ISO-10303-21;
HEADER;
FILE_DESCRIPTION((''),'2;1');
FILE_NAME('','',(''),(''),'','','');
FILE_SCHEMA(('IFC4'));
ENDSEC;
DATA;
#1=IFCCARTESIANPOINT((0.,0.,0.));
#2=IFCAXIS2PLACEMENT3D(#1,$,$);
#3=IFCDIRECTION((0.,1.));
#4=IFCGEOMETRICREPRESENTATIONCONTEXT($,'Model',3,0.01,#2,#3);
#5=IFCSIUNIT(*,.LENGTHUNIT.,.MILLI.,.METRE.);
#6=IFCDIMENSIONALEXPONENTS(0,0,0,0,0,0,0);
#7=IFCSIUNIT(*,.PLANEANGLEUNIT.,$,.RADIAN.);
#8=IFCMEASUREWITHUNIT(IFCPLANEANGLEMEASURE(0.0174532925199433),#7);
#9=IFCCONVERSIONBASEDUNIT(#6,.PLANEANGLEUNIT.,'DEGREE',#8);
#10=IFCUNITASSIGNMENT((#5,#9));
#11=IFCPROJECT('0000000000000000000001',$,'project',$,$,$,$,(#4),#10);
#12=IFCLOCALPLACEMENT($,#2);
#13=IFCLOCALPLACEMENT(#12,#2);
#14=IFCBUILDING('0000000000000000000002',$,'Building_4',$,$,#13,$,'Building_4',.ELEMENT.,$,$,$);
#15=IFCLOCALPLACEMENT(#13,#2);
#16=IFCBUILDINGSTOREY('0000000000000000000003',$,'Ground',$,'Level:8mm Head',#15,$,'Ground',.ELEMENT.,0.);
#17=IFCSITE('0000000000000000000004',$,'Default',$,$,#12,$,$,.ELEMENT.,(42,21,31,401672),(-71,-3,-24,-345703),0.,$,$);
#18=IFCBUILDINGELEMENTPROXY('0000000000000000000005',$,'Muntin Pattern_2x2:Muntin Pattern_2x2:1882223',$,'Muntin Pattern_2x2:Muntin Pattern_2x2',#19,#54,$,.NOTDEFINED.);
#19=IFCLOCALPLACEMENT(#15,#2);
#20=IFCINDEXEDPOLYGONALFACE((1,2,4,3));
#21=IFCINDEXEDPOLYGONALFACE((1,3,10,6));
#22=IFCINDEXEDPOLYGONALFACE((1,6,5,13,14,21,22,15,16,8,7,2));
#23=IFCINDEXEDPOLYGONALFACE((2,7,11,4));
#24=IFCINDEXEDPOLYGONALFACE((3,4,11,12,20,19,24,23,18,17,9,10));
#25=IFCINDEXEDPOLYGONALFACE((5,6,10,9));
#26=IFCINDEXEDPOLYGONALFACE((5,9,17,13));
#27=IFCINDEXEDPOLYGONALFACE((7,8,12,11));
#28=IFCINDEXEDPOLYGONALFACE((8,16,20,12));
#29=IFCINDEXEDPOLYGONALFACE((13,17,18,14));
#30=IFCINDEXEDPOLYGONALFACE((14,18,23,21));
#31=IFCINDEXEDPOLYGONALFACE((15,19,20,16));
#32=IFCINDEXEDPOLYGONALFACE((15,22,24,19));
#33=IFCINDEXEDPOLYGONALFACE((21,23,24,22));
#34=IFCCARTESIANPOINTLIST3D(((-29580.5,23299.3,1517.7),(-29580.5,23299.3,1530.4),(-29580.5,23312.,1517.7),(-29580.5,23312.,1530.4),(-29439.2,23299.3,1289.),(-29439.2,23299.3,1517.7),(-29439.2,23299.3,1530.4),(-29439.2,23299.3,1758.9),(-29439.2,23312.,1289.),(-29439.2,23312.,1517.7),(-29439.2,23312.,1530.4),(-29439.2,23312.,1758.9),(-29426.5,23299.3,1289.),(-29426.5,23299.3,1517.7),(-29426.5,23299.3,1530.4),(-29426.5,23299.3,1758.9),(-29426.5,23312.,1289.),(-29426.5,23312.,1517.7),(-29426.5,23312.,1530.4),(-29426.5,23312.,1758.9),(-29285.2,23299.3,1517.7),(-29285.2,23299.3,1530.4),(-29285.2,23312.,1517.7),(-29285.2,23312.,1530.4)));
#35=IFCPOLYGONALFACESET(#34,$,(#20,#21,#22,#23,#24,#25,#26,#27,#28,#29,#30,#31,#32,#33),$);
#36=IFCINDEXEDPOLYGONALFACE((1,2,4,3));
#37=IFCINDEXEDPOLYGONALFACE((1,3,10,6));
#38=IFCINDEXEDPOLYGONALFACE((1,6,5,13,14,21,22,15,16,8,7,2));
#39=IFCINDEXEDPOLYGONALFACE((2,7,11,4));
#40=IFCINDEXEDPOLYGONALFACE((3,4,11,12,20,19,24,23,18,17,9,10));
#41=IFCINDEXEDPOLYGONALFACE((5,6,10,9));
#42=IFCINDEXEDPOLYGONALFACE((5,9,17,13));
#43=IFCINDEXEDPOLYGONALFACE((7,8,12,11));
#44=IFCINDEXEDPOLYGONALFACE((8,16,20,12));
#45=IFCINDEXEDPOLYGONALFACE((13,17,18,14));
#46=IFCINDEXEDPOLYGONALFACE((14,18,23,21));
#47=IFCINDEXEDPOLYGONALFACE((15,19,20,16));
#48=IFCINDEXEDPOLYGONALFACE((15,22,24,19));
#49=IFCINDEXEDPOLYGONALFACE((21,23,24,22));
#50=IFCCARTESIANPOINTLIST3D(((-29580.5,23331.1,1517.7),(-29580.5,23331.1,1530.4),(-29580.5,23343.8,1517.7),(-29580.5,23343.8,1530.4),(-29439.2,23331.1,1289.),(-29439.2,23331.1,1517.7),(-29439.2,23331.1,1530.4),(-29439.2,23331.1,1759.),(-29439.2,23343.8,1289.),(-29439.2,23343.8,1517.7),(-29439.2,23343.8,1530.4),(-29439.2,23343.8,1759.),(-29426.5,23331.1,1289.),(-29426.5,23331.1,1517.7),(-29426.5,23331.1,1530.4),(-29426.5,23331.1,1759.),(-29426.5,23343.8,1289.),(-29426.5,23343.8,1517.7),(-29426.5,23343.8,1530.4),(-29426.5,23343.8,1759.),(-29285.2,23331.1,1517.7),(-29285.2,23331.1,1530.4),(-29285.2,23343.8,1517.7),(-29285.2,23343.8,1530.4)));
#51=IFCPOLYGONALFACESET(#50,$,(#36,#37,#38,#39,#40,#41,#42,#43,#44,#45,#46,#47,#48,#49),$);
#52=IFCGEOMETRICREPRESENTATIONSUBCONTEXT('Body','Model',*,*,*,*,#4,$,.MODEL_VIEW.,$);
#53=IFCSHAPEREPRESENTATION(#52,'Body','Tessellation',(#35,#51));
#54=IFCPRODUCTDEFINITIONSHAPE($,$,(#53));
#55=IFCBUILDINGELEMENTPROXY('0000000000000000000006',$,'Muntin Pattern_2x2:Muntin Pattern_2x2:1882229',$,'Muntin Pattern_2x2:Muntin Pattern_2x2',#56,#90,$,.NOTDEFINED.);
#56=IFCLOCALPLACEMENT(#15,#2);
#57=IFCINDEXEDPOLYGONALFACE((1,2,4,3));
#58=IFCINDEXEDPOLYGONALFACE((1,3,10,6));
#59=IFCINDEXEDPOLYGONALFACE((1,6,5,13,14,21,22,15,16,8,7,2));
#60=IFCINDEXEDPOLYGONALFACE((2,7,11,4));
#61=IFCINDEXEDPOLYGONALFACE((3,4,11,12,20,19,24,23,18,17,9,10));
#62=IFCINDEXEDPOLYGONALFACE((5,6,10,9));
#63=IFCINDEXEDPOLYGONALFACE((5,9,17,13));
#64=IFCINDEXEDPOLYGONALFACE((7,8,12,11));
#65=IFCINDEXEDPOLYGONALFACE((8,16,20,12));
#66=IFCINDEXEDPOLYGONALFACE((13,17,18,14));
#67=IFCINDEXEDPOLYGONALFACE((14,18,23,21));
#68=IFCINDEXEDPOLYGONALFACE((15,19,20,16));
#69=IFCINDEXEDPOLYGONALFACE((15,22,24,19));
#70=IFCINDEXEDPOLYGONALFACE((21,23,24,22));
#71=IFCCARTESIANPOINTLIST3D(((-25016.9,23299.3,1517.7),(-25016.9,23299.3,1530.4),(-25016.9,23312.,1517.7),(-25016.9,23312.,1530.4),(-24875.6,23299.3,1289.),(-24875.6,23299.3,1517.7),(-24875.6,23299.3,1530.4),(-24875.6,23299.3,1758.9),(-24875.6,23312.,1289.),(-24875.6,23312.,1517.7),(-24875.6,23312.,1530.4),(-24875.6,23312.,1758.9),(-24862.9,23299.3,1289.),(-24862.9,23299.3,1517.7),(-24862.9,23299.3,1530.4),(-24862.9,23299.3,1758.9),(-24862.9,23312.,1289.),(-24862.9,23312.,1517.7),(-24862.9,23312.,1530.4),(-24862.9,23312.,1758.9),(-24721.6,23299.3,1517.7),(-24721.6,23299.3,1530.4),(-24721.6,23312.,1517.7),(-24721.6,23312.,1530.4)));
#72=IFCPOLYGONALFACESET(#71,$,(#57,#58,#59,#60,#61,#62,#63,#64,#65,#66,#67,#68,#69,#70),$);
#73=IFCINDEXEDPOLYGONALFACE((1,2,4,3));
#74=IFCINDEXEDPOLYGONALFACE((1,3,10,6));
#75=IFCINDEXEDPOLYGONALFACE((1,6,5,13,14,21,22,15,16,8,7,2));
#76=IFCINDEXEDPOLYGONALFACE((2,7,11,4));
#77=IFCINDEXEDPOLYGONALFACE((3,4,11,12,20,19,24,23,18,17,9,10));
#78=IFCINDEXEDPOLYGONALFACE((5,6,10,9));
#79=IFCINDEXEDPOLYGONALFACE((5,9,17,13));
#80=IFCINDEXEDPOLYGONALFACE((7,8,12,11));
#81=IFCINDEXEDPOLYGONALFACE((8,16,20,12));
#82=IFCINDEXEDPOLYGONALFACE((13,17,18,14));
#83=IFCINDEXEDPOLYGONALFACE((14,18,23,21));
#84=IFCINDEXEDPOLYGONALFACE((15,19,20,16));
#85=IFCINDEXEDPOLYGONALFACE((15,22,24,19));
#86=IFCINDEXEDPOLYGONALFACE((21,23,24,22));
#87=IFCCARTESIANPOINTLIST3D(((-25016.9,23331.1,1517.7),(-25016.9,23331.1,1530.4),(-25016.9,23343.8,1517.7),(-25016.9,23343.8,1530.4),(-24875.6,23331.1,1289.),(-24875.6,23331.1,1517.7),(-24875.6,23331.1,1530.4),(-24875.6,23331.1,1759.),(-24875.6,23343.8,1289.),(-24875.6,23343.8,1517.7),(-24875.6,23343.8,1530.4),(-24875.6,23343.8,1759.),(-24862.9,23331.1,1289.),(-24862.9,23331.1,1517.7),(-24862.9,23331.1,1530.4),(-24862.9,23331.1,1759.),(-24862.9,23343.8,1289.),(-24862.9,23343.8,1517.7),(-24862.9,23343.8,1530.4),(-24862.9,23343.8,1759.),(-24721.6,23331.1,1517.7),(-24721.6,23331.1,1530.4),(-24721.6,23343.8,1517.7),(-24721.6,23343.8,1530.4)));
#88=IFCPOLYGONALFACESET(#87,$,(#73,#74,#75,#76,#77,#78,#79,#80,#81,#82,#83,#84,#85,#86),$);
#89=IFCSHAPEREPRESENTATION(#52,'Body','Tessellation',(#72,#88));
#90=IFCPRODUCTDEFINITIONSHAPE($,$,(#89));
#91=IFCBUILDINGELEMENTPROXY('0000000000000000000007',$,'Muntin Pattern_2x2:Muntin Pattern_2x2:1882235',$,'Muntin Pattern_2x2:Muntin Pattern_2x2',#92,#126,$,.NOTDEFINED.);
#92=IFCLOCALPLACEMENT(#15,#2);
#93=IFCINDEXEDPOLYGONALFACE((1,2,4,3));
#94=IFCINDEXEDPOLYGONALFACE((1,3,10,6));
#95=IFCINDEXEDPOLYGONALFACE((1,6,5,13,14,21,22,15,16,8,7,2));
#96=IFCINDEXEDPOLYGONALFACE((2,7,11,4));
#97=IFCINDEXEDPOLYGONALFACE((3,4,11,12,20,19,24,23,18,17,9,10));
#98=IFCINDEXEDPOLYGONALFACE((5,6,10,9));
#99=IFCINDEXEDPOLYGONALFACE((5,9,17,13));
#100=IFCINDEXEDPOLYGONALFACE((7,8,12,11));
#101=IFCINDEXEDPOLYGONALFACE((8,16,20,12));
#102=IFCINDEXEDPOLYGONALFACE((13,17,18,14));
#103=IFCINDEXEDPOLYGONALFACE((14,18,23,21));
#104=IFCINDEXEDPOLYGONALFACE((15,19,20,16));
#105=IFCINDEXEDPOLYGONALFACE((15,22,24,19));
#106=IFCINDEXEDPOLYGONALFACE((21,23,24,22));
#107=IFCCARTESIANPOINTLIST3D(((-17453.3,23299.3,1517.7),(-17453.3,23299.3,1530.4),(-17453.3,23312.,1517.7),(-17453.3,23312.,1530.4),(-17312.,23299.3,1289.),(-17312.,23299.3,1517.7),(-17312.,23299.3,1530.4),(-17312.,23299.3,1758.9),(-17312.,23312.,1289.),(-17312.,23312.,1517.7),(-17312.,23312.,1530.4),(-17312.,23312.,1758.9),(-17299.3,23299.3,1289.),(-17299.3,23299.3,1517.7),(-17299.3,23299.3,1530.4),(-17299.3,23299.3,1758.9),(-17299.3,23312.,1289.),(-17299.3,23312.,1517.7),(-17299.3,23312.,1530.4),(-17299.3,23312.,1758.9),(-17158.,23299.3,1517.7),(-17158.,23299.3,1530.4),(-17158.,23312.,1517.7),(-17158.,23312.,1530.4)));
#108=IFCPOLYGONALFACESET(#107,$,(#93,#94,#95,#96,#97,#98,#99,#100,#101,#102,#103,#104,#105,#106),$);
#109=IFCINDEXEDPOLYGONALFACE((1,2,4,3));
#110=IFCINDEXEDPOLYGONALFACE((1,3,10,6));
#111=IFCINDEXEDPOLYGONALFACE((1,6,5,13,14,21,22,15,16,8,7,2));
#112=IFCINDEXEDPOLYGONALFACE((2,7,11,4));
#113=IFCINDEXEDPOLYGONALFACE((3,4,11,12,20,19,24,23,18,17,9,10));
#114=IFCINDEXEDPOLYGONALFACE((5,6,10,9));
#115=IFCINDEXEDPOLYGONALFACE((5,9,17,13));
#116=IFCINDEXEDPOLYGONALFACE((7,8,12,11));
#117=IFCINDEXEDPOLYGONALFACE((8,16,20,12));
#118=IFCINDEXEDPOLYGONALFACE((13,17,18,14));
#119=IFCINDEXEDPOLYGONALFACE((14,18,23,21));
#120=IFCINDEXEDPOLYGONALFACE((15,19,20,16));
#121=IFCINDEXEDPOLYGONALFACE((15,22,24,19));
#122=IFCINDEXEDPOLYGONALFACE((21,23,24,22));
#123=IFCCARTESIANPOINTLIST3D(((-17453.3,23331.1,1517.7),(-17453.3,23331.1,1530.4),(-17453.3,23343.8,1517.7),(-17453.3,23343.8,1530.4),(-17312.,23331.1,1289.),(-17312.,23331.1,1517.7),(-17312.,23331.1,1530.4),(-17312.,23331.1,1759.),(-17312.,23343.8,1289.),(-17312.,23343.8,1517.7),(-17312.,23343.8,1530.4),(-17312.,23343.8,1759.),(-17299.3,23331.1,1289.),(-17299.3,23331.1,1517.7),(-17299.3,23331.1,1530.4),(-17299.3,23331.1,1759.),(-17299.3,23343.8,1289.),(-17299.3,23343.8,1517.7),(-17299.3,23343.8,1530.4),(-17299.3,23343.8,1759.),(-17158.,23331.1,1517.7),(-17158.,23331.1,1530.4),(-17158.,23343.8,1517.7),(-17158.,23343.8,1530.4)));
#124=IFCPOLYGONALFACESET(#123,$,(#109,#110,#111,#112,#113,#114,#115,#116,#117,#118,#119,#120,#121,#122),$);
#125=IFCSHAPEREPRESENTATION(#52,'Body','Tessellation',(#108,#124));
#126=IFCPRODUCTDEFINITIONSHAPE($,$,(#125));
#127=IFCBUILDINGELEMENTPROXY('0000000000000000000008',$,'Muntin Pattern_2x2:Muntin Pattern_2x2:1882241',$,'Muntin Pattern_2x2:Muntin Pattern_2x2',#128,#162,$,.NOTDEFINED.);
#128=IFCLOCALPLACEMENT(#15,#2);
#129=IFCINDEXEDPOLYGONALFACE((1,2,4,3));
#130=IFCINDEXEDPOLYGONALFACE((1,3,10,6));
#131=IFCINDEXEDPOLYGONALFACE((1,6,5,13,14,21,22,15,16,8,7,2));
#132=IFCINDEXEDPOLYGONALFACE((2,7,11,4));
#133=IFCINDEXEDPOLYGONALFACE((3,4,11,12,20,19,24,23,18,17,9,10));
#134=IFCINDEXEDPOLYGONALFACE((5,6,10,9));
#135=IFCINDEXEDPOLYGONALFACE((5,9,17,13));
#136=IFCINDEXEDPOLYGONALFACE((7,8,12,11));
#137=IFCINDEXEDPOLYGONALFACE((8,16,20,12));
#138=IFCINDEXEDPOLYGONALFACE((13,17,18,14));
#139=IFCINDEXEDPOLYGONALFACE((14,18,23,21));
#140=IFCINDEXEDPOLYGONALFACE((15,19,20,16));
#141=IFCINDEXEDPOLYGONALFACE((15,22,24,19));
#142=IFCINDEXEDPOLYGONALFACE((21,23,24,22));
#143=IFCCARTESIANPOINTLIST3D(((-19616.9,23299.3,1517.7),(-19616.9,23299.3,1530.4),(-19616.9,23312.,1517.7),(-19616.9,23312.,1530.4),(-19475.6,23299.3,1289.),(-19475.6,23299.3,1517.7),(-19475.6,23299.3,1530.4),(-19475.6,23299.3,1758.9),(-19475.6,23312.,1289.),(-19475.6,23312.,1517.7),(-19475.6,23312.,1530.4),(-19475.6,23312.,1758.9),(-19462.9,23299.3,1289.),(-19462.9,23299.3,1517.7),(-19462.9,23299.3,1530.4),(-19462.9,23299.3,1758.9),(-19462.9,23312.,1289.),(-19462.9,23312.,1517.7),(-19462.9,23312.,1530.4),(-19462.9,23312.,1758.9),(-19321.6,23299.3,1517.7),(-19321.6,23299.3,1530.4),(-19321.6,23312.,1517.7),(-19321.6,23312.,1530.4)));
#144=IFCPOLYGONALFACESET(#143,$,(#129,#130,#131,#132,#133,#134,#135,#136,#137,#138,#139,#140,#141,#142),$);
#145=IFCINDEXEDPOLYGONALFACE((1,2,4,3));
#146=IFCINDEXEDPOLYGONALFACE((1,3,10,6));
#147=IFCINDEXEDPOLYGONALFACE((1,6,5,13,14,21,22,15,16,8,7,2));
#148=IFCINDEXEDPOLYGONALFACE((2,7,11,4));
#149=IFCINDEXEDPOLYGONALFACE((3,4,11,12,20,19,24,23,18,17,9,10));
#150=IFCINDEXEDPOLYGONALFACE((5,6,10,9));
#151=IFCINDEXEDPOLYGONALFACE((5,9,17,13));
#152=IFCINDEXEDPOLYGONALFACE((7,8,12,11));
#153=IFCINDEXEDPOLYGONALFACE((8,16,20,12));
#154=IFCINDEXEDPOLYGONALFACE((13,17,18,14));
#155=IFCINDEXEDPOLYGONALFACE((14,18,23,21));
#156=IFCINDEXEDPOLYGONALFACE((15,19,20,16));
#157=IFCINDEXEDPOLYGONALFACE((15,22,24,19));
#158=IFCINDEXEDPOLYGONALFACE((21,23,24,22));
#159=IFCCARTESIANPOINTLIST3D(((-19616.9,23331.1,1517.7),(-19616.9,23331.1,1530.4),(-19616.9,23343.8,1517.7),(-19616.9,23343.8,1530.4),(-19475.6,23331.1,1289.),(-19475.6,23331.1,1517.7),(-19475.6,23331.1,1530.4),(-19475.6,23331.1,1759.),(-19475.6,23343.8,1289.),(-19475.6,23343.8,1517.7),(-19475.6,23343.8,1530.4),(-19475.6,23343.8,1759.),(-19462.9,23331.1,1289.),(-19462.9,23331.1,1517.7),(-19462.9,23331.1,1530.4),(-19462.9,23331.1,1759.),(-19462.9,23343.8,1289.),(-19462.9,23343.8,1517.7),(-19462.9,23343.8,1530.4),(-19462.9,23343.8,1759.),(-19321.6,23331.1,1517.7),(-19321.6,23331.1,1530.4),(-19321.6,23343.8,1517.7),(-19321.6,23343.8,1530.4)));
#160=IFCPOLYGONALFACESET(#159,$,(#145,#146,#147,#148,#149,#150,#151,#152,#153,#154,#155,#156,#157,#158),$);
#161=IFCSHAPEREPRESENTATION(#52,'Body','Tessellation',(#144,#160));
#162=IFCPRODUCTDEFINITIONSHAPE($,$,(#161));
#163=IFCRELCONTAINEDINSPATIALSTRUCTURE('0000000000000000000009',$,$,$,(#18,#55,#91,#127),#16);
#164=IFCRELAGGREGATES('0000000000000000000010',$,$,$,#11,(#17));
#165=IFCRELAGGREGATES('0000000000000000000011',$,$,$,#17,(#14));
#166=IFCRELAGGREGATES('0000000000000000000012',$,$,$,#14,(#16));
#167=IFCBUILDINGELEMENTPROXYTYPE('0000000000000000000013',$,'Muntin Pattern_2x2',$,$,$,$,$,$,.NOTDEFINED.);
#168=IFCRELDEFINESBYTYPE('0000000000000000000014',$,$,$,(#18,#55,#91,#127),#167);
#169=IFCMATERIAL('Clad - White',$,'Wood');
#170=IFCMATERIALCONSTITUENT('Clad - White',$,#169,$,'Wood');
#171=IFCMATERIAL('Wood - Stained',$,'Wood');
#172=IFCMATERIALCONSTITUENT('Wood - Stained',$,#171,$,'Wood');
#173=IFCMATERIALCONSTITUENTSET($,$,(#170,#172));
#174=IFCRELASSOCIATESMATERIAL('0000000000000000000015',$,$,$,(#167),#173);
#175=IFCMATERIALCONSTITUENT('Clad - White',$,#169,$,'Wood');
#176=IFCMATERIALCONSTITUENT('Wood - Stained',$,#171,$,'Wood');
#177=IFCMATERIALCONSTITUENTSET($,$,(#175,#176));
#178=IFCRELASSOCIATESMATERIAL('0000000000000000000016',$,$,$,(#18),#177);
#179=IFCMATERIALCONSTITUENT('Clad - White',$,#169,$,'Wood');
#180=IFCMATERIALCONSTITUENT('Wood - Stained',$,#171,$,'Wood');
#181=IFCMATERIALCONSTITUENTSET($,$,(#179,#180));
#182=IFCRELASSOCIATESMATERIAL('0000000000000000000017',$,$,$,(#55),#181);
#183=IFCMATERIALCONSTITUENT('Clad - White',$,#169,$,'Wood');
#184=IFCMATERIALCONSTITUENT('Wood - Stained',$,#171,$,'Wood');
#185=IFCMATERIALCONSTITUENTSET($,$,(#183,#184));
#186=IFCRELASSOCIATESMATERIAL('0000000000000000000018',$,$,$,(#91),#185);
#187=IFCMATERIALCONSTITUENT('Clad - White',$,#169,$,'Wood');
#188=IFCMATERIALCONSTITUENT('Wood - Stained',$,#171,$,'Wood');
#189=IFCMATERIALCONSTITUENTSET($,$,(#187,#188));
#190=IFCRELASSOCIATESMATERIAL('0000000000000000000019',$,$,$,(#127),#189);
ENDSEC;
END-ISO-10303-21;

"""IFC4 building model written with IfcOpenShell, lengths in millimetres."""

from ifc_helpers import new_model, entity, si_unit, converted_unit, direction, frame, origin, place, context, subcontext, project, spatial, indexed_curve, outline, extrude, source, transform, mapped, material, constituent, constituent_set, type_object, type_shapes, element, save


model = new_model("IFC4")

# Units and contexts
model_context = context("Model", 3, precision=0.01, world=origin(), true_north=direction((0.0, 1.0)))
body_context = subcontext(model_context, "Body", "Model", "MODEL_VIEW")
ifc_project = project(units=[si_unit("LENGTHUNIT", "METRE", prefix="MILLI"), converted_unit("PLANEANGLEUNIT", "DEGREE", entity("IfcPlaneAngleMeasure", 0.0174532925199433), si_unit("PLANEANGLEUNIT", "RADIAN"), dimensions=[0, 0, 0, 0, 0, 0, 0])], contexts=[model_context])

# Site, building, storey
site_placement = place(None, origin())
site = spatial("IfcSite", under=ifc_project, at=site_placement, Name="Default", CompositionType="ELEMENT", RefLatitude=(42, 21, 31, 401672), RefLongitude=(-71, -3, -24, -345703), RefElevation=0.0)
building_placement = place(site_placement, origin())
building = spatial("IfcBuilding", under=site, at=building_placement, Name="Building_4", LongName="Building_4", CompositionType="ELEMENT")
storey_placement = place(building_placement, origin())
storey = spatial("IfcBuildingStorey", under=building, at=storey_placement, Name="Ground", ObjectType="Level:8mm Head", LongName="Ground", CompositionType="ELEMENT", Elevation=0.0)

# Building element proxies
ifc_material_1 = material(Name="Clad - White", Category="Wood")
ifc_material_2 = material(Name="Wood - Stained", Category="Wood")
ifc_constituent_1 = constituent(ifc_material_1, Name="Clad - White", Category="Wood")
ifc_constituent_2 = constituent(ifc_material_2, Name="Wood - Stained", Category="Wood")
ifc_constituent_set_1 = constituent_set(constituents=[ifc_constituent_1, ifc_constituent_2])
ifc_constituent_3 = constituent(ifc_material_1, Name="Clad - White", Category="Wood")
ifc_constituent_4 = constituent(ifc_material_2, Name="Wood - Stained", Category="Wood")
ifc_constituent_set_2 = constituent_set(constituents=[ifc_constituent_3, ifc_constituent_4])
building_element_proxy_type_1 = type_object("IfcBuildingElementProxyType", Name="Muntin Pattern_2x2", PredefinedType="NOTDEFINED", material=ifc_constituent_set_2)
shared_shape_1 = source(origin(), body_context, "Body", "SweptSolid", [
    extrude(outline(indexed_curve([(6.4, -6.4), (234.9, -6.4), (234.9, 6.3), (6.4, 6.3), (6.4, 147.6), (-6.3, 147.6), (-6.3, 6.3), (-235.0, 6.3), (-235.0, -6.4), (-6.3, -6.4), (-6.3, -147.6), (6.4, -147.6), (6.4, -6.4)], self_intersect=False)), frame((0.0, 9.5, 235.0), z_axis=(0.0, 1.0, 0.0), x_axis=(0.0, 0.0, 1.0)), (0.0, 0.0, 1.0), 12.7),
    extrude(outline(indexed_curve([(6.4, -6.4), (235.0, -6.4), (235.0, 6.3), (6.4, 6.3), (6.4, 147.6), (-6.3, 147.6), (-6.3, 6.3), (-235.0, 6.3), (-235.0, -6.4), (-6.3, -6.4), (-6.3, -147.6), (6.4, -147.6), (6.4, -6.4)], self_intersect=False)), frame((0.0, -22.2, 235.0), z_axis=(0.0, 1.0, 0.0), x_axis=(0.0, 0.0, 1.0)), (0.0, 0.0, 1.0), 12.7),
])
type_shapes(building_element_proxy_type_1, [shared_shape_1])
proxy_1_placement = place(storey_placement, frame((-29432.9, 23321.5, 1289.0), z_axis=(0.0, 0.0, 1.0), x_axis=(-1.0, 0.0, 0.0)))
element("IfcBuildingElementProxy", 1, at=proxy_1_placement, inside=storey, type_object=building_element_proxy_type_1, material=ifc_constituent_set_1, Name="Muntin Pattern_2x2:Muntin Pattern_2x2:1882223", ObjectType="Muntin Pattern_2x2:Muntin Pattern_2x2", PredefinedType="NOTDEFINED", context=body_context, shape_type="MappedRepresentation", body=[
    mapped(shared_shape_1, transform((0.0, 0.0, 0.0), scale=1.0)),
])
ifc_constituent_5 = constituent(ifc_material_1, Name="Clad - White", Category="Wood")
ifc_constituent_6 = constituent(ifc_material_2, Name="Wood - Stained", Category="Wood")
ifc_constituent_set_3 = constituent_set(constituents=[ifc_constituent_5, ifc_constituent_6])
proxy_2_placement = place(storey_placement, frame((-24869.3, 23321.5, 1289.0), z_axis=(0.0, 0.0, 1.0), x_axis=(-1.0, 0.0, 0.0)))
element("IfcBuildingElementProxy", 2, at=proxy_2_placement, inside=storey, type_object=building_element_proxy_type_1, material=ifc_constituent_set_3, Name="Muntin Pattern_2x2:Muntin Pattern_2x2:1882229", ObjectType="Muntin Pattern_2x2:Muntin Pattern_2x2", PredefinedType="NOTDEFINED", context=body_context, shape_type="MappedRepresentation", body=[
    mapped(shared_shape_1, transform((0.0, 0.0, 0.0), scale=1.0)),
])
ifc_constituent_7 = constituent(ifc_material_1, Name="Clad - White", Category="Wood")
ifc_constituent_8 = constituent(ifc_material_2, Name="Wood - Stained", Category="Wood")
ifc_constituent_set_4 = constituent_set(constituents=[ifc_constituent_7, ifc_constituent_8])
proxy_3_placement = place(storey_placement, frame((-17305.7, 23321.5, 1289.0), z_axis=(0.0, 0.0, 1.0), x_axis=(-1.0, 0.0, 0.0)))
element("IfcBuildingElementProxy", 3, at=proxy_3_placement, inside=storey, type_object=building_element_proxy_type_1, material=ifc_constituent_set_4, Name="Muntin Pattern_2x2:Muntin Pattern_2x2:1882235", ObjectType="Muntin Pattern_2x2:Muntin Pattern_2x2", PredefinedType="NOTDEFINED", context=body_context, shape_type="MappedRepresentation", body=[
    mapped(shared_shape_1, transform((0.0, 0.0, 0.0), scale=1.0)),
])
ifc_constituent_9 = constituent(ifc_material_1, Name="Clad - White", Category="Wood")
ifc_constituent_10 = constituent(ifc_material_2, Name="Wood - Stained", Category="Wood")
ifc_constituent_set_5 = constituent_set(constituents=[ifc_constituent_9, ifc_constituent_10])
proxy_4_placement = place(storey_placement, frame((-19469.3, 23321.5, 1289.0), z_axis=(0.0, 0.0, 1.0), x_axis=(-1.0, 0.0, 0.0)))
element("IfcBuildingElementProxy", 4, at=proxy_4_placement, inside=storey, type_object=building_element_proxy_type_1, material=ifc_constituent_set_5, Name="Muntin Pattern_2x2:Muntin Pattern_2x2:1882241", ObjectType="Muntin Pattern_2x2:Muntin Pattern_2x2", PredefinedType="NOTDEFINED", context=body_context, shape_type="MappedRepresentation", body=[
    mapped(shared_shape_1, transform((0.0, 0.0, 0.0), scale=1.0)),
])

save(model, "model.ifc")
